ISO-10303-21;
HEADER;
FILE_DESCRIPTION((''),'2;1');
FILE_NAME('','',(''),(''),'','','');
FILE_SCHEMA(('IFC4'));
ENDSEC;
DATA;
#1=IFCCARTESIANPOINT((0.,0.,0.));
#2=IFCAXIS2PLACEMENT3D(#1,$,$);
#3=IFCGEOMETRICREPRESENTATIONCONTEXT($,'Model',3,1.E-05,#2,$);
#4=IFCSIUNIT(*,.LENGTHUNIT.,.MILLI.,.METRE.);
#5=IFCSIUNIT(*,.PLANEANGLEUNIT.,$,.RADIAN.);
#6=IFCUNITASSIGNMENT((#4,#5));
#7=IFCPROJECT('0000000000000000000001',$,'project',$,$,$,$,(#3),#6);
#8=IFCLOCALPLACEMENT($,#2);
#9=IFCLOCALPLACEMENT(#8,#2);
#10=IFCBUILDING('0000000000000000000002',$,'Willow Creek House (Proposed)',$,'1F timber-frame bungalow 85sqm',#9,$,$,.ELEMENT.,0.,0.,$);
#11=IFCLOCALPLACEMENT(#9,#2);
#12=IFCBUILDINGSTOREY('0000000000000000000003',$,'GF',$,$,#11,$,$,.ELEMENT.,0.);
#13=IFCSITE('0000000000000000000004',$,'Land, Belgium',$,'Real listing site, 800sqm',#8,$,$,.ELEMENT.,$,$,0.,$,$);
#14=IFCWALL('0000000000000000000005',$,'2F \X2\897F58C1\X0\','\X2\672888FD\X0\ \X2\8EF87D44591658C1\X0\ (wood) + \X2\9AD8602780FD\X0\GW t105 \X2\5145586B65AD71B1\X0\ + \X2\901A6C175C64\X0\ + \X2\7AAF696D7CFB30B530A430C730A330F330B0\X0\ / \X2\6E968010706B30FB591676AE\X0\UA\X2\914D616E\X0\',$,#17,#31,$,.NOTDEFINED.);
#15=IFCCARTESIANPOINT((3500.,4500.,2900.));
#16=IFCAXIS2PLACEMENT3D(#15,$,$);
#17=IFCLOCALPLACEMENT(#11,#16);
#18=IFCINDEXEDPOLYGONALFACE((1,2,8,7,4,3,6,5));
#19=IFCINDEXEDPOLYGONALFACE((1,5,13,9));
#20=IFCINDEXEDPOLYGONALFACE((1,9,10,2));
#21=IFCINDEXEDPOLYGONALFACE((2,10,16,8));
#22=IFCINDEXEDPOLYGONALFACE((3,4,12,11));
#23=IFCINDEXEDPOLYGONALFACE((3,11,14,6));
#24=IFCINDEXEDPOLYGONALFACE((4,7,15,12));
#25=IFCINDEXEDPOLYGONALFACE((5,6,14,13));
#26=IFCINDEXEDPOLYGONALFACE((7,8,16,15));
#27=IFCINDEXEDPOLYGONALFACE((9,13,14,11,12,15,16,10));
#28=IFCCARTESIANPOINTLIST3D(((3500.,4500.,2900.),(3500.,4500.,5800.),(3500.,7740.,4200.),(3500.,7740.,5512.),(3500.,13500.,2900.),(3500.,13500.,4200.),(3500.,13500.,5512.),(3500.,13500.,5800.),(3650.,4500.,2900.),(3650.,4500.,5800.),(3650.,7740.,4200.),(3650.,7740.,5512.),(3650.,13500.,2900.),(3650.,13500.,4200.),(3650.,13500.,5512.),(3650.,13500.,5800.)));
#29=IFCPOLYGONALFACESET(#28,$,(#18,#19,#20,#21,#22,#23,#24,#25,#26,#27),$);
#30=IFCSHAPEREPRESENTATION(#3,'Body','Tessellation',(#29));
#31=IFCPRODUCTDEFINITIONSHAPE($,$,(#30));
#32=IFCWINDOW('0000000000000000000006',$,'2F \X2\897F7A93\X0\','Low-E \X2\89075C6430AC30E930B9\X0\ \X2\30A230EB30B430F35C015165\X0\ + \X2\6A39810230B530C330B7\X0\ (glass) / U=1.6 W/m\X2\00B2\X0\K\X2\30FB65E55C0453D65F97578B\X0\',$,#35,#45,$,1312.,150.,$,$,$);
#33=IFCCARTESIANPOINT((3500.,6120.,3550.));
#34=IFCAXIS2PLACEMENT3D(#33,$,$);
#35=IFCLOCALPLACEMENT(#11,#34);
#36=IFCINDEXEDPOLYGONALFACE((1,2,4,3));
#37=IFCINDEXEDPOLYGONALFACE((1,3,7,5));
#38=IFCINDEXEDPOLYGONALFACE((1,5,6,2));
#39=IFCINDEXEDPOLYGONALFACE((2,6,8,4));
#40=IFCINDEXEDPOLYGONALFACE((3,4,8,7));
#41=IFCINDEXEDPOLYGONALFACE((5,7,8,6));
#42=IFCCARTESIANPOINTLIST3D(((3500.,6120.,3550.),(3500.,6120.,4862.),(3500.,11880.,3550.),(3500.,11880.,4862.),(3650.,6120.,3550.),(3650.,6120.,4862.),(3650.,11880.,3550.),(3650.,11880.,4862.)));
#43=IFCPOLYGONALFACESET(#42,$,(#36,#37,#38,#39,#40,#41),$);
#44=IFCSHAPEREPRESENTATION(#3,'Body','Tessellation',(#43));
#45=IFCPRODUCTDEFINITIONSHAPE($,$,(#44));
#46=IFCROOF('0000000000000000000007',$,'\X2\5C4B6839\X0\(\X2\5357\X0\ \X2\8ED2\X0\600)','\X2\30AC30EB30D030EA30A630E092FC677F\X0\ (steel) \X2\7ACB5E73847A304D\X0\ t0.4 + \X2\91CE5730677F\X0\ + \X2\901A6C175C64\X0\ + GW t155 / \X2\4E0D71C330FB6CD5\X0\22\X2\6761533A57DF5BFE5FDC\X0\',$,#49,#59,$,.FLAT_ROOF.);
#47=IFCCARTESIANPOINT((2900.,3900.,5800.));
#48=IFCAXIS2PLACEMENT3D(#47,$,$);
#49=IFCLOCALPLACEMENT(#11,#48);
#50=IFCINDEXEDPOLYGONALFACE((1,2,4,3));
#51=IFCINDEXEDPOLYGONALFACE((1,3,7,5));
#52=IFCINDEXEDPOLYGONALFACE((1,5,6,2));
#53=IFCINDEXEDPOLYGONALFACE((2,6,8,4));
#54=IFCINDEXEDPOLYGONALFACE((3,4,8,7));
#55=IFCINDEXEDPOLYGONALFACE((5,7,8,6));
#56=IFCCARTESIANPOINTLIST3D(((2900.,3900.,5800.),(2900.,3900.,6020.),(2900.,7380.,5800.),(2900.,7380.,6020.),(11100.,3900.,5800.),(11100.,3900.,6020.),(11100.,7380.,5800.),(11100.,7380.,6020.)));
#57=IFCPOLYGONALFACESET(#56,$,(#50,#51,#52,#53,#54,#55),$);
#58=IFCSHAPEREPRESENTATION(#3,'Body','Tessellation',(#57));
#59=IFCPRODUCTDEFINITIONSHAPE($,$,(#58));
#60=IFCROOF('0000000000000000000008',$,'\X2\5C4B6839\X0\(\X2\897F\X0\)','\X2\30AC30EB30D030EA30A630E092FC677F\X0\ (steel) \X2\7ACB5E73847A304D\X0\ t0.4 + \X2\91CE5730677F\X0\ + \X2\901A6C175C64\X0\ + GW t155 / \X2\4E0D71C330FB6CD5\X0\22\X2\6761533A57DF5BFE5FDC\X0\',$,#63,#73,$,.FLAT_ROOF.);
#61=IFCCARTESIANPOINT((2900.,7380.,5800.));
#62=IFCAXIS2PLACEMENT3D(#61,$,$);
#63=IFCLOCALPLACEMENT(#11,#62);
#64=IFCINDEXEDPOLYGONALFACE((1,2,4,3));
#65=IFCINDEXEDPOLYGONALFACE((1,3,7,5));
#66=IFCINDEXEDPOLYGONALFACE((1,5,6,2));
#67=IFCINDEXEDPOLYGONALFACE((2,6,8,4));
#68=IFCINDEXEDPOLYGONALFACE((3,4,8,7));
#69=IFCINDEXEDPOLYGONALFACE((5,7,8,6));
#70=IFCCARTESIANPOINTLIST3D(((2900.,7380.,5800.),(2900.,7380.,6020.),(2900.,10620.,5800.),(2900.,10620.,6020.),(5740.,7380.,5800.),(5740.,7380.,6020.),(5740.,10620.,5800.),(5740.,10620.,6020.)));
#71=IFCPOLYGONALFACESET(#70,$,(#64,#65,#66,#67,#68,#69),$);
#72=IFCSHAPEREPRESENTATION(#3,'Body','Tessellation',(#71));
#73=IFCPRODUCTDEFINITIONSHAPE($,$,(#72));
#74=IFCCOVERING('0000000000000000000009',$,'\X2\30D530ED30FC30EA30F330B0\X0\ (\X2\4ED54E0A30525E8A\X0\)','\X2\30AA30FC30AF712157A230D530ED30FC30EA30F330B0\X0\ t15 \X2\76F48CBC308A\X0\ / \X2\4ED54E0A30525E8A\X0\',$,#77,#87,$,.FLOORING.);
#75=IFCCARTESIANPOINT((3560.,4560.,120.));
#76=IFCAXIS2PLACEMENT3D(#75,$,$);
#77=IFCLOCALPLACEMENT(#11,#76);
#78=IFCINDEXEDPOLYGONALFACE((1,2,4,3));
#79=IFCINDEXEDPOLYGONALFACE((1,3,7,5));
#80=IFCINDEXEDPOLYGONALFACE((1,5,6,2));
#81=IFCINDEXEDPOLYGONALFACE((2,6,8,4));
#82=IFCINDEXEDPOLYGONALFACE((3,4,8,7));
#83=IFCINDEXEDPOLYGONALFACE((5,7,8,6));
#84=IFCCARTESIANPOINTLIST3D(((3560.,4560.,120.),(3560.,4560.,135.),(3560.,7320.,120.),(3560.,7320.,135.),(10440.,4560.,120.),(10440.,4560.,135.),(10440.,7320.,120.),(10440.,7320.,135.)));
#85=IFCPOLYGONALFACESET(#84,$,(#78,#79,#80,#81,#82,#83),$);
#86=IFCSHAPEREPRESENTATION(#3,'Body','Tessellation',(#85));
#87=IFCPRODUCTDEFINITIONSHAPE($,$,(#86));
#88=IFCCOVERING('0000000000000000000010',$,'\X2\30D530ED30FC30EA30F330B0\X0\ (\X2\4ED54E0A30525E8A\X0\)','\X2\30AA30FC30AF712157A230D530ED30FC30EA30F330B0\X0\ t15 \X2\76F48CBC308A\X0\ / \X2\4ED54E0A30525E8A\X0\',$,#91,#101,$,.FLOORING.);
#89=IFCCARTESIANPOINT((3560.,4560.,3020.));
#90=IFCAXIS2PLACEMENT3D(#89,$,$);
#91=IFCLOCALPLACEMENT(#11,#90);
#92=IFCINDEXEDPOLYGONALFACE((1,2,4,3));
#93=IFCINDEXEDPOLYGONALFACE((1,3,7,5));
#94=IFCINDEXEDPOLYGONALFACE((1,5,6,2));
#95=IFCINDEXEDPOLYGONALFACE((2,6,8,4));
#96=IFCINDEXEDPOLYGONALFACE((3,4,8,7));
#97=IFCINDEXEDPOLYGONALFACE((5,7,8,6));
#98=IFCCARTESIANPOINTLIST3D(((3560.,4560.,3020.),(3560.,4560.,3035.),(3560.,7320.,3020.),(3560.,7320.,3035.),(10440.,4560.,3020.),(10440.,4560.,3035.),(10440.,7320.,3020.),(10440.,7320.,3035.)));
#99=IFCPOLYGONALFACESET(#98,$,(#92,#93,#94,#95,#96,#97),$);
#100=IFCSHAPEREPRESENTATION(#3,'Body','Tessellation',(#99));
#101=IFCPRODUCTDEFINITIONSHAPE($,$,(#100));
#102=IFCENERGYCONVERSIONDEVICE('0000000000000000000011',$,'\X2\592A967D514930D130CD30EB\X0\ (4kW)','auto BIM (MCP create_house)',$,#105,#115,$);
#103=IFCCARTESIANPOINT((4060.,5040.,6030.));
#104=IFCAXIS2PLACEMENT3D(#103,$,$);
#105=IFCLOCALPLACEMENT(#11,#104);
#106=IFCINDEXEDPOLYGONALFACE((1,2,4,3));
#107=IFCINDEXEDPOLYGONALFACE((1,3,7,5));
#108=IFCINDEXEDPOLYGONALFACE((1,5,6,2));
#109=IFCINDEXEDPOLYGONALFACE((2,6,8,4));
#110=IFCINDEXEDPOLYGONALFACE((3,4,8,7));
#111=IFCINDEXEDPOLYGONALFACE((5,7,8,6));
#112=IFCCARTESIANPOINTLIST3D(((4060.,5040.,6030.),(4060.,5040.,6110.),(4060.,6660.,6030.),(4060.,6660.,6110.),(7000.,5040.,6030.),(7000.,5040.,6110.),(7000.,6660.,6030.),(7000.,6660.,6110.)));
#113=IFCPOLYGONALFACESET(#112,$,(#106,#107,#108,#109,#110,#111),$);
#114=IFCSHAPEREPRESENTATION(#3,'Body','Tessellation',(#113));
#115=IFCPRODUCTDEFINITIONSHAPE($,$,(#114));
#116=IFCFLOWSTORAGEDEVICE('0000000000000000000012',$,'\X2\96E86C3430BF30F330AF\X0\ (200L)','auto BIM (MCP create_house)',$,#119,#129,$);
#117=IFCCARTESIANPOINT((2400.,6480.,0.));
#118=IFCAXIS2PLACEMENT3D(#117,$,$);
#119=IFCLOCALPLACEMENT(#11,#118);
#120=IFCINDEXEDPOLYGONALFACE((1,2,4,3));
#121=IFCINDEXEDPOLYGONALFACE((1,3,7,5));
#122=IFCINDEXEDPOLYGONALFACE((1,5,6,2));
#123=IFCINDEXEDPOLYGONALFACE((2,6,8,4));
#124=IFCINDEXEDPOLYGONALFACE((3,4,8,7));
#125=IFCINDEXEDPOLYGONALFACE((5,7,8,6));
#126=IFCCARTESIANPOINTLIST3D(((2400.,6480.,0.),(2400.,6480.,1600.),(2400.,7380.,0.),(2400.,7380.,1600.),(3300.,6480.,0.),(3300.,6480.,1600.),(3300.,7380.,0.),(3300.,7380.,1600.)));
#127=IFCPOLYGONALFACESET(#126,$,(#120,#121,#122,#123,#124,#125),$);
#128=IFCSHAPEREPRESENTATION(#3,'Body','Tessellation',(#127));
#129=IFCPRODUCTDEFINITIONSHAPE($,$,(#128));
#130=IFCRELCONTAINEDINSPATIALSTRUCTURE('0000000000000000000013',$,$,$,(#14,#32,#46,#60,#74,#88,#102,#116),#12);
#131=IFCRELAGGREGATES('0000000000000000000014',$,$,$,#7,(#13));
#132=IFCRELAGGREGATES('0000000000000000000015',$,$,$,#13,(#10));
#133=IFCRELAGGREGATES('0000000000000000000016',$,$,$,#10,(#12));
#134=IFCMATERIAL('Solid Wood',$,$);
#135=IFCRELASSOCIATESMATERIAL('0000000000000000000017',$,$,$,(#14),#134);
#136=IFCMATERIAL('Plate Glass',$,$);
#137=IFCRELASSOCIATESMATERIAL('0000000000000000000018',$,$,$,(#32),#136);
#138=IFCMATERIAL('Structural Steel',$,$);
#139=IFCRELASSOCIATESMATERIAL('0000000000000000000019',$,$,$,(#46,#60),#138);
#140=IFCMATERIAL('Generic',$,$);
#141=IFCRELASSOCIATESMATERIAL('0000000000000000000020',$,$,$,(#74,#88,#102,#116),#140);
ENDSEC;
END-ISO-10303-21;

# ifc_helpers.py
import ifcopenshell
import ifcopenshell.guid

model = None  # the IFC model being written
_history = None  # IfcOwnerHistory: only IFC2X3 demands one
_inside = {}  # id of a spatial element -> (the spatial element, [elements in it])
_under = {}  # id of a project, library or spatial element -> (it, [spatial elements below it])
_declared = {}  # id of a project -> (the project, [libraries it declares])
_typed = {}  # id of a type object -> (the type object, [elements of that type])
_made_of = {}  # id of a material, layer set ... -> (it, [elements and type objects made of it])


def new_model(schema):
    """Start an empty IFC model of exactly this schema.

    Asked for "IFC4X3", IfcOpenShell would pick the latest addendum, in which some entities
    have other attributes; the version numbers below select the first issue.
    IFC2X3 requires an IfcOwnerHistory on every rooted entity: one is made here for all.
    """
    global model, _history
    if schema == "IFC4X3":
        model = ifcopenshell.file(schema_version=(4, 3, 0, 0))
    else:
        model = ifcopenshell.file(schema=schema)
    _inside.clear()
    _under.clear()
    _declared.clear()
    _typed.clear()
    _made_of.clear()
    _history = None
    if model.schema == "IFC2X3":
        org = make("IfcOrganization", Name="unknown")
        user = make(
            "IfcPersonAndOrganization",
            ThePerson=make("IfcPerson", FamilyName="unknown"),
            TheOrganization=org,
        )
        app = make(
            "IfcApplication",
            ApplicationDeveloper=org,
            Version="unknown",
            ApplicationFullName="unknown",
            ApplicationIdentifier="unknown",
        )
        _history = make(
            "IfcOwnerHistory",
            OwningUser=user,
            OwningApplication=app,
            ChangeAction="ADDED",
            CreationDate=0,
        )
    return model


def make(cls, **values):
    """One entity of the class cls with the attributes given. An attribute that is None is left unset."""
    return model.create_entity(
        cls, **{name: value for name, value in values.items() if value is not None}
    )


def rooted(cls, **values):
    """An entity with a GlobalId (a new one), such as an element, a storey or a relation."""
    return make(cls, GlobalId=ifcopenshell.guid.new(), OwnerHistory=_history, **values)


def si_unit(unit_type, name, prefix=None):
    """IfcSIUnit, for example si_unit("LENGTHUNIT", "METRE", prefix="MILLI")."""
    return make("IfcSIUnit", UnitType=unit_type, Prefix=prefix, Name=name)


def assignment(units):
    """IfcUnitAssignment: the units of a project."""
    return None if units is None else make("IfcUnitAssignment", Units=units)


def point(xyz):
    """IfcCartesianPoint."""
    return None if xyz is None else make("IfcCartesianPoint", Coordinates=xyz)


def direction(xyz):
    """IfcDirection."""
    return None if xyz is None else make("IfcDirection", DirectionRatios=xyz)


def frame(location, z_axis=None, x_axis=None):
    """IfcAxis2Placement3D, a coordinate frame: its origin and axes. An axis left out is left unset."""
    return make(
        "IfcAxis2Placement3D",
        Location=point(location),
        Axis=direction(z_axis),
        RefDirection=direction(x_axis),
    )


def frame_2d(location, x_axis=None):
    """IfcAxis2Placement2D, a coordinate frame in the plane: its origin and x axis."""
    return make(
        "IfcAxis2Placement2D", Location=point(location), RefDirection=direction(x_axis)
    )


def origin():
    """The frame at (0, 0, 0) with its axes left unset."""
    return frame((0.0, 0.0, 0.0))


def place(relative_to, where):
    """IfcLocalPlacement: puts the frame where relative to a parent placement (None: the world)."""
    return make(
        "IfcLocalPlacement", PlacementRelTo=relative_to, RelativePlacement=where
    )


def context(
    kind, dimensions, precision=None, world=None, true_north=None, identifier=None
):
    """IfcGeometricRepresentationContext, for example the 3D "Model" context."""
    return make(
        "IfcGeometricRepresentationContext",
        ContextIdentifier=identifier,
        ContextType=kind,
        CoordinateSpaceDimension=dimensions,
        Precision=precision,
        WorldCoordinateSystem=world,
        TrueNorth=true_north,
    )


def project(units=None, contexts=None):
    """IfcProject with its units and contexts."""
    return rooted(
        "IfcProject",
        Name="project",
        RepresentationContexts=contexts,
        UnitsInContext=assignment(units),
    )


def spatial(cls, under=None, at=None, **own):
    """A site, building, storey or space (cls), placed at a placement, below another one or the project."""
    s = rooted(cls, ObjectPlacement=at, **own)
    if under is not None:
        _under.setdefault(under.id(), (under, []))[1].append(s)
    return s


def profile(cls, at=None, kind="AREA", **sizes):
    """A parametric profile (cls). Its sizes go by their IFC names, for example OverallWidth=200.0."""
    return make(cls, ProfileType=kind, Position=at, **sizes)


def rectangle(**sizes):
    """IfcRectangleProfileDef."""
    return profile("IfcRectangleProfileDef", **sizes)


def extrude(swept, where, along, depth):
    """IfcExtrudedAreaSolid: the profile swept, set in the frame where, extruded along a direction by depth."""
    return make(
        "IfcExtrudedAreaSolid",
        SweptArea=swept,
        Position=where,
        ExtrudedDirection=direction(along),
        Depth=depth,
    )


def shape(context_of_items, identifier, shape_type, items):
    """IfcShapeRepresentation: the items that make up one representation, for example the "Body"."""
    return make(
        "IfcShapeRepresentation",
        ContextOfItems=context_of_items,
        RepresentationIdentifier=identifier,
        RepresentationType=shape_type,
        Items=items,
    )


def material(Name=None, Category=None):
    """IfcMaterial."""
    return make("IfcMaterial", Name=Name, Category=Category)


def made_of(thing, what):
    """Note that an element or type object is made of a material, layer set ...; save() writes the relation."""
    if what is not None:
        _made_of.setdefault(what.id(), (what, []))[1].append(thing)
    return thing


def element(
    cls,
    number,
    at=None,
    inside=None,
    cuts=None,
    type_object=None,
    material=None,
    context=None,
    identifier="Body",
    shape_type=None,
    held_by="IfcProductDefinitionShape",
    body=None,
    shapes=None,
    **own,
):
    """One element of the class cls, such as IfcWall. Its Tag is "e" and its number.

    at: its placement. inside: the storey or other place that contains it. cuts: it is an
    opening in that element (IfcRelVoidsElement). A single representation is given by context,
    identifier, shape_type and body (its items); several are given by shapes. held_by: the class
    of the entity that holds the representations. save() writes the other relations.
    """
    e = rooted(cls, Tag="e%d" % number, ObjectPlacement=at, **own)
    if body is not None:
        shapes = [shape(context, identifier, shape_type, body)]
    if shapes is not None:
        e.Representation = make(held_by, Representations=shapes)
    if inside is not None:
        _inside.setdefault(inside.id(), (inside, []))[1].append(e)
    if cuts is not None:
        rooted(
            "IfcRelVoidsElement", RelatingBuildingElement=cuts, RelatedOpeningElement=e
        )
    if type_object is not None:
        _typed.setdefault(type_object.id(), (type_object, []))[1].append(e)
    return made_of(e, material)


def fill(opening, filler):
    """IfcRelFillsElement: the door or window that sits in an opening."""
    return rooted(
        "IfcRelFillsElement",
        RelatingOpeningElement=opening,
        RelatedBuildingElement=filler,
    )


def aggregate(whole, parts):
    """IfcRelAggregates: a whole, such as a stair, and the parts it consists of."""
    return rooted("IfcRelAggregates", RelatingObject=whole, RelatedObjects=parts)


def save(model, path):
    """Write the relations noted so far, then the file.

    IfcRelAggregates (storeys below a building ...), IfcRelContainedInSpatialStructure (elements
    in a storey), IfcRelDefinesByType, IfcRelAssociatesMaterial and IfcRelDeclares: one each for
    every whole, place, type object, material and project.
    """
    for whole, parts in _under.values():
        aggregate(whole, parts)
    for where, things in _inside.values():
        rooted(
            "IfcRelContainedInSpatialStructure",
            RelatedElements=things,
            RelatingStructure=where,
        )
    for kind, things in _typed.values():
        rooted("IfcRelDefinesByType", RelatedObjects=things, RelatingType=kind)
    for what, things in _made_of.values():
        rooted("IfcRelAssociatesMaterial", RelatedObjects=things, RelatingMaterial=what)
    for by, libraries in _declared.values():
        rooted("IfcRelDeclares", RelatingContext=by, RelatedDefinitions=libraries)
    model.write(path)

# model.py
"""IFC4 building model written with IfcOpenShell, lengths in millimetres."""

from ifc_helpers import new_model, si_unit, frame, frame_2d, origin, place, context, project, spatial, rectangle, extrude, material, element, fill, save


model = new_model("IFC4")

# Units and contexts
model_context = context("Model", 3, precision=1e-05, world=origin())
ifc_project = project(units=[si_unit("LENGTHUNIT", "METRE", prefix="MILLI"), si_unit("PLANEANGLEUNIT", "RADIAN")], contexts=[model_context])

# Site, building, storey
site_placement = place(None, origin())
site = spatial("IfcSite", under=ifc_project, at=site_placement, Name="Land, Belgium", ObjectType="Real listing site, 800sqm", CompositionType="ELEMENT", RefElevation=0.0)
building_placement = place(site_placement, origin())
building = spatial("IfcBuilding", under=site, at=building_placement, Name="Willow Creek House (Proposed)", ObjectType="1F timber-frame bungalow 85sqm", CompositionType="ELEMENT", ElevationOfRefHeight=0.0, ElevationOfTerrain=0.0)
storey_placement = place(building_placement, origin())
storey = spatial("IfcBuildingStorey", under=building, at=storey_placement, Name="GF", CompositionType="ELEMENT", Elevation=0.0)

# Shared definitions
ifc_material_1 = material(Name="Solid Wood")
ifc_material_2 = material(Name="Generic")

# Shared definitions
ifc_material_3 = material(Name="Plate Glass")

# Wall, opening, window
wall_1_placement = place(storey_placement, frame((3500.0, 4500.0, 2900.0)))
wall_1 = element("IfcWall", 1, at=wall_1_placement, inside=storey, material=ifc_material_1, Name="2F 西壁", Description="木製 軸組外壁 (wood) + 高性能GW t105 充填断熱 + 通気層 + 窯業系サイディング / 準耐火・外皮UA配慮", PredefinedType="NOTDEFINED", context=model_context, shape_type="SweptSolid", body=[
    extrude(rectangle(XDim=150.0, YDim=9000.0, at=frame_2d((75.0, 4500.0))), frame((3500.0, 4500.0, 2900.0)), (0.0, 0.0, 1.0), 2900.0),
])
opening_1_placement = place(storey_placement, frame((3500.0, 6120.0, 3550.0)))
opening_1 = element("IfcOpeningElement", 2, at=opening_1_placement, cuts=wall_1, PredefinedType="NOTDEFINED", context=model_context, shape_type="SweptSolid", body=[
    extrude(rectangle(XDim=150.0, YDim=5760.0, at=frame_2d((75.0, 2880.0))), frame((3500.0, 6120.0, 3550.0)), (0.0, 0.0, 1.0), 1312.0),
])
window_1_placement = place(storey_placement, frame((3500.0, 6120.0, 3550.0)))
window_1 = element("IfcWindow", 3, at=window_1_placement, inside=storey, material=ifc_material_3, Name="2F 西窓", Description="Low-E 複層ガラス アルゴン封入 + 樹脂サッシ (glass) / U=1.6 W/m²K・日射取得型", OverallHeight=1312.0, OverallWidth=150.0, context=model_context, shape_type="SweptSolid", body=[
    extrude(rectangle(XDim=150.0, YDim=5760.0, at=frame_2d((75.0, 2880.0))), frame((3500.0, 6120.0, 3550.0)), (0.0, 0.0, 1.0), 1312.0),
])
fill(opening_1, window_1)

# Roofs
ifc_material_4 = material(Name="Structural Steel")
roof_1_placement = place(storey_placement, frame((2900.0, 3900.0, 5800.0)))
element("IfcRoof", 4, at=roof_1_placement, inside=storey, material=ifc_material_4, Name="屋根(南 軒600)", Description="ガルバリウム鋼板 (steel) 立平葺き t0.4 + 野地板 + 通気層 + GW t155 / 不燃・法22条区域対応", PredefinedType="FLAT_ROOF", context=model_context, shape_type="SweptSolid", body=[
    extrude(rectangle(XDim=8200.0, YDim=3480.0, at=frame_2d((4100.0, 1740.0))), frame((2900.0, 3900.0, 5800.0)), (0.0, 0.0, 1.0), 220.0),
])
roof_2_placement = place(storey_placement, frame((2900.0, 7380.0, 5800.0)))
element("IfcRoof", 5, at=roof_2_placement, inside=storey, material=ifc_material_4, Name="屋根(西)", Description="ガルバリウム鋼板 (steel) 立平葺き t0.4 + 野地板 + 通気層 + GW t155 / 不燃・法22条区域対応", PredefinedType="FLAT_ROOF", context=model_context, shape_type="SweptSolid", body=[
    extrude(rectangle(XDim=2840.0, YDim=3240.0, at=frame_2d((1420.0, 1620.0))), frame((2900.0, 7380.0, 5800.0)), (0.0, 0.0, 1.0), 220.0),
])

# Coverings
covering_1_placement = place(storey_placement, frame((3560.0, 4560.0, 120.0)))
element("IfcCovering", 6, at=covering_1_placement, inside=storey, material=ifc_material_2, Name="フローリング (仕上げ床)", Description="オーク無垢フローリング t15 直貼り / 仕上げ床", PredefinedType="FLOORING", context=model_context, shape_type="SweptSolid", body=[
    extrude(rectangle(XDim=6880.0, YDim=2760.0, at=frame_2d((3440.0, 1380.0))), frame((3560.0, 4560.0, 120.0)), (0.0, 0.0, 1.0), 15.0),
])
covering_2_placement = place(storey_placement, frame((3560.0, 4560.0, 3020.0)))
element("IfcCovering", 7, at=covering_2_placement, inside=storey, material=ifc_material_2, Name="フローリング (仕上げ床)", Description="オーク無垢フローリング t15 直貼り / 仕上げ床", PredefinedType="FLOORING", context=model_context, shape_type="SweptSolid", body=[
    extrude(rectangle(XDim=6880.0, YDim=2760.0, at=frame_2d((3440.0, 1380.0))), frame((3560.0, 4560.0, 3020.0)), (0.0, 0.0, 1.0), 15.0),
])

# Energy conversion device
energy_conversion_device_placement = place(storey_placement, frame((4060.0, 5040.0, 6030.0)))
element("IfcEnergyConversionDevice", 8, at=energy_conversion_device_placement, inside=storey, material=ifc_material_2, Name="太陽光パネル (4kW)", Description="auto BIM (MCP create_house)", context=model_context, shape_type="SweptSolid", body=[
    extrude(rectangle(XDim=2940.0, YDim=1620.0, at=frame_2d((1470.0, 810.0))), frame((4060.0, 5040.0, 6030.0)), (0.0, 0.0, 1.0), 80.0),
])

# Flow storage device
flow_storage_device_placement = place(storey_placement, frame((2400.0, 6480.0, 0.0)))
element("IfcFlowStorageDevice", 9, at=flow_storage_device_placement, inside=storey, material=ifc_material_2, Name="雨水タンク (200L)", Description="auto BIM (MCP create_house)", context=model_context, shape_type="SweptSolid", body=[
    extrude(rectangle(XDim=900.0, YDim=900.0, at=frame_2d((450.0, 450.0))), frame((2400.0, 6480.0, 0.0)), (0.0, 0.0, 1.0), 1600.0),
])

save(model, "model.ifc")
